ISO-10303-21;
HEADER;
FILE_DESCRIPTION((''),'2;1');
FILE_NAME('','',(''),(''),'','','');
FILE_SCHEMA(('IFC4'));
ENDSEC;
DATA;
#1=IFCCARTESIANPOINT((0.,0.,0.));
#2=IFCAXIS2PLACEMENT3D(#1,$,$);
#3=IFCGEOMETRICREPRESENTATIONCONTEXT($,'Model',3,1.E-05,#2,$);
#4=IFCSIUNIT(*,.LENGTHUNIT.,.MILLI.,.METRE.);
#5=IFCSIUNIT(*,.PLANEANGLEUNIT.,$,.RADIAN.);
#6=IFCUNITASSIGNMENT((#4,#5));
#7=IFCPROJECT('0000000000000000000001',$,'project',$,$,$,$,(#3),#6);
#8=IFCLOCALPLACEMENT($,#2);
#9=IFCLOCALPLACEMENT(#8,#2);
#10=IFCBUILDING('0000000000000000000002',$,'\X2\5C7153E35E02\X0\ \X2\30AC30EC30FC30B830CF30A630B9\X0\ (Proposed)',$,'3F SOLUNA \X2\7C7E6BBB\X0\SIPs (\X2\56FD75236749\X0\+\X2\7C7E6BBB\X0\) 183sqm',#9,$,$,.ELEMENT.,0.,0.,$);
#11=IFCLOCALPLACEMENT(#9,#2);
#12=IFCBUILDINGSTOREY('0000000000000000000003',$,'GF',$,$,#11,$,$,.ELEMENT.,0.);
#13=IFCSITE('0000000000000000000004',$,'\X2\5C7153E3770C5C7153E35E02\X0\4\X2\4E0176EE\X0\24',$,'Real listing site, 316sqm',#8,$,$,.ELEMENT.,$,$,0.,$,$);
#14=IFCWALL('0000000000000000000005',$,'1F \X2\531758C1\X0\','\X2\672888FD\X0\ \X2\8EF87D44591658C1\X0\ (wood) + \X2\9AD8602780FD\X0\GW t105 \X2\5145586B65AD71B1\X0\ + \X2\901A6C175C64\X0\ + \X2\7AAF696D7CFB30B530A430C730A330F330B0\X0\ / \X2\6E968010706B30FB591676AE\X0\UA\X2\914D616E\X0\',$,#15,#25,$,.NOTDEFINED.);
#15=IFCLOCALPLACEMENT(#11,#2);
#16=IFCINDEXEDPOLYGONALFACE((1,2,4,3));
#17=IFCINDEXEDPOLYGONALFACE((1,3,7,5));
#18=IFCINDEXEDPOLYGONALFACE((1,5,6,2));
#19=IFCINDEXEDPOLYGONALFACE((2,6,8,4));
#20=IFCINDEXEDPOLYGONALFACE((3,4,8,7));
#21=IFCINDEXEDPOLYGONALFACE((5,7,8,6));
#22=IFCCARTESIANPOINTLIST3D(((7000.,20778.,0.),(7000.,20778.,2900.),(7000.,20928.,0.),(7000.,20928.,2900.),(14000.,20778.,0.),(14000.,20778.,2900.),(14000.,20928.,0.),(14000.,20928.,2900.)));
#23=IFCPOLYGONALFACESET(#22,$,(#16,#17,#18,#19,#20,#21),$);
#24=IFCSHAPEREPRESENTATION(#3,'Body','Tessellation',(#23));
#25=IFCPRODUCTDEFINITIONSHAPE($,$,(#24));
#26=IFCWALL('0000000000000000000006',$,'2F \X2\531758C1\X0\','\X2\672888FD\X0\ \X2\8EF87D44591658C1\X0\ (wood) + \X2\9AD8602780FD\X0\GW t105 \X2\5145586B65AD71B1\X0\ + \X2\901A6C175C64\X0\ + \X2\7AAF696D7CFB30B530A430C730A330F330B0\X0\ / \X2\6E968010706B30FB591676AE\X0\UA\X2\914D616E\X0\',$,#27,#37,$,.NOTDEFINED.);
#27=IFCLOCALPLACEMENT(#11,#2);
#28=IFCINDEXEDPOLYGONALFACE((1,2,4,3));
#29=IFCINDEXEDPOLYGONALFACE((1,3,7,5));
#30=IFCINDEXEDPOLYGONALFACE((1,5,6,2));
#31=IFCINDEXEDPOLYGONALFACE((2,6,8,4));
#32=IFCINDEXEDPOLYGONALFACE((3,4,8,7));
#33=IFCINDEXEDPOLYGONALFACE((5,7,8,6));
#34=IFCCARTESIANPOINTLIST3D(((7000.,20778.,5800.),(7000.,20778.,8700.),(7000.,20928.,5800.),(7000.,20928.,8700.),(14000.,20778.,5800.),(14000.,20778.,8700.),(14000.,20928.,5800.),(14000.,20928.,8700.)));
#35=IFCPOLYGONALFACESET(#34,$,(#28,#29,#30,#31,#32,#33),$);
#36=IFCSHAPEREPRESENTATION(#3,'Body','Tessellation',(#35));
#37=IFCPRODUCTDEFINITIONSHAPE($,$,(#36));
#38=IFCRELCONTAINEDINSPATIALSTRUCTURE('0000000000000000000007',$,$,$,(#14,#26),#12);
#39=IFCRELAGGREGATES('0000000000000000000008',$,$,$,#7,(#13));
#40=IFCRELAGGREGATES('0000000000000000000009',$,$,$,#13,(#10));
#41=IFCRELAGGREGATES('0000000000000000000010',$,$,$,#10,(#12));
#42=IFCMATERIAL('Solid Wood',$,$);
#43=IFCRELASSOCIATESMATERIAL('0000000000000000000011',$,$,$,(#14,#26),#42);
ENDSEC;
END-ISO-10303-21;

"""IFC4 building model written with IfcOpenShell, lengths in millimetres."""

from ifc_helpers import new_model, si_unit, frame, frame_2d, origin, place, context, project, spatial, rectangle, extrude, material, element, save


model = new_model("IFC4")

# Units and contexts
model_context = context("Model", 3, precision=1e-05, world=origin())
ifc_project = project(units=[si_unit("LENGTHUNIT", "METRE", prefix="MILLI"), si_unit("PLANEANGLEUNIT", "RADIAN")], contexts=[model_context])

# Site, building, storey
site_placement = place(None, origin())
site = spatial("IfcSite", under=ifc_project, at=site_placement, Name="山口県山口市4丁目24", ObjectType="Real listing site, 316sqm", CompositionType="ELEMENT", RefElevation=0.0)
building_placement = place(site_placement, origin())
building = spatial("IfcBuilding", under=site, at=building_placement, Name="山口市 ガレージハウス (Proposed)", ObjectType="3F SOLUNA 籾殻SIPs (国産杉+籾殻) 183sqm", CompositionType="ELEMENT", ElevationOfRefHeight=0.0, ElevationOfTerrain=0.0)
storey_placement = place(building_placement, origin())
storey = spatial("IfcBuildingStorey", under=building, at=storey_placement, Name="GF", CompositionType="ELEMENT", Elevation=0.0)

# Shared definitions
ifc_material_1 = material(Name="Solid Wood")

# Wall
wall_1_placement = place(storey_placement, frame((3500.0, 10389.0, 0.0)))
element("IfcWall", 1, at=wall_1_placement, inside=storey, material=ifc_material_1, Name="1F 北壁", Description="木製 軸組外壁 (wood) + 高性能GW t105 充填断熱 + 通気層 + 窯業系サイディング / 準耐火・外皮UA配慮", PredefinedType="NOTDEFINED", context=model_context, shape_type="SweptSolid", body=[
    extrude(rectangle(XDim=7000.0, YDim=150.0, at=frame_2d((3500.0, 75.0))), frame((3500.0, 10389.0, 0.0)), (0.0, 0.0, 1.0), 2900.0),
])

# Wall
wall_2_placement = place(storey_placement, frame((3500.0, 10389.0, 2900.0)))
element("IfcWall", 2, at=wall_2_placement, inside=storey, material=ifc_material_1, Name="2F 北壁", Description="木製 軸組外壁 (wood) + 高性能GW t105 充填断熱 + 通気層 + 窯業系サイディング / 準耐火・外皮UA配慮", PredefinedType="NOTDEFINED", context=model_context, shape_type="SweptSolid", body=[
    extrude(rectangle(XDim=7000.0, YDim=150.0, at=frame_2d((3500.0, 75.0))), frame((3500.0, 10389.0, 2900.0)), (0.0, 0.0, 1.0), 2900.0),
])

save(model, "model.ifc")
